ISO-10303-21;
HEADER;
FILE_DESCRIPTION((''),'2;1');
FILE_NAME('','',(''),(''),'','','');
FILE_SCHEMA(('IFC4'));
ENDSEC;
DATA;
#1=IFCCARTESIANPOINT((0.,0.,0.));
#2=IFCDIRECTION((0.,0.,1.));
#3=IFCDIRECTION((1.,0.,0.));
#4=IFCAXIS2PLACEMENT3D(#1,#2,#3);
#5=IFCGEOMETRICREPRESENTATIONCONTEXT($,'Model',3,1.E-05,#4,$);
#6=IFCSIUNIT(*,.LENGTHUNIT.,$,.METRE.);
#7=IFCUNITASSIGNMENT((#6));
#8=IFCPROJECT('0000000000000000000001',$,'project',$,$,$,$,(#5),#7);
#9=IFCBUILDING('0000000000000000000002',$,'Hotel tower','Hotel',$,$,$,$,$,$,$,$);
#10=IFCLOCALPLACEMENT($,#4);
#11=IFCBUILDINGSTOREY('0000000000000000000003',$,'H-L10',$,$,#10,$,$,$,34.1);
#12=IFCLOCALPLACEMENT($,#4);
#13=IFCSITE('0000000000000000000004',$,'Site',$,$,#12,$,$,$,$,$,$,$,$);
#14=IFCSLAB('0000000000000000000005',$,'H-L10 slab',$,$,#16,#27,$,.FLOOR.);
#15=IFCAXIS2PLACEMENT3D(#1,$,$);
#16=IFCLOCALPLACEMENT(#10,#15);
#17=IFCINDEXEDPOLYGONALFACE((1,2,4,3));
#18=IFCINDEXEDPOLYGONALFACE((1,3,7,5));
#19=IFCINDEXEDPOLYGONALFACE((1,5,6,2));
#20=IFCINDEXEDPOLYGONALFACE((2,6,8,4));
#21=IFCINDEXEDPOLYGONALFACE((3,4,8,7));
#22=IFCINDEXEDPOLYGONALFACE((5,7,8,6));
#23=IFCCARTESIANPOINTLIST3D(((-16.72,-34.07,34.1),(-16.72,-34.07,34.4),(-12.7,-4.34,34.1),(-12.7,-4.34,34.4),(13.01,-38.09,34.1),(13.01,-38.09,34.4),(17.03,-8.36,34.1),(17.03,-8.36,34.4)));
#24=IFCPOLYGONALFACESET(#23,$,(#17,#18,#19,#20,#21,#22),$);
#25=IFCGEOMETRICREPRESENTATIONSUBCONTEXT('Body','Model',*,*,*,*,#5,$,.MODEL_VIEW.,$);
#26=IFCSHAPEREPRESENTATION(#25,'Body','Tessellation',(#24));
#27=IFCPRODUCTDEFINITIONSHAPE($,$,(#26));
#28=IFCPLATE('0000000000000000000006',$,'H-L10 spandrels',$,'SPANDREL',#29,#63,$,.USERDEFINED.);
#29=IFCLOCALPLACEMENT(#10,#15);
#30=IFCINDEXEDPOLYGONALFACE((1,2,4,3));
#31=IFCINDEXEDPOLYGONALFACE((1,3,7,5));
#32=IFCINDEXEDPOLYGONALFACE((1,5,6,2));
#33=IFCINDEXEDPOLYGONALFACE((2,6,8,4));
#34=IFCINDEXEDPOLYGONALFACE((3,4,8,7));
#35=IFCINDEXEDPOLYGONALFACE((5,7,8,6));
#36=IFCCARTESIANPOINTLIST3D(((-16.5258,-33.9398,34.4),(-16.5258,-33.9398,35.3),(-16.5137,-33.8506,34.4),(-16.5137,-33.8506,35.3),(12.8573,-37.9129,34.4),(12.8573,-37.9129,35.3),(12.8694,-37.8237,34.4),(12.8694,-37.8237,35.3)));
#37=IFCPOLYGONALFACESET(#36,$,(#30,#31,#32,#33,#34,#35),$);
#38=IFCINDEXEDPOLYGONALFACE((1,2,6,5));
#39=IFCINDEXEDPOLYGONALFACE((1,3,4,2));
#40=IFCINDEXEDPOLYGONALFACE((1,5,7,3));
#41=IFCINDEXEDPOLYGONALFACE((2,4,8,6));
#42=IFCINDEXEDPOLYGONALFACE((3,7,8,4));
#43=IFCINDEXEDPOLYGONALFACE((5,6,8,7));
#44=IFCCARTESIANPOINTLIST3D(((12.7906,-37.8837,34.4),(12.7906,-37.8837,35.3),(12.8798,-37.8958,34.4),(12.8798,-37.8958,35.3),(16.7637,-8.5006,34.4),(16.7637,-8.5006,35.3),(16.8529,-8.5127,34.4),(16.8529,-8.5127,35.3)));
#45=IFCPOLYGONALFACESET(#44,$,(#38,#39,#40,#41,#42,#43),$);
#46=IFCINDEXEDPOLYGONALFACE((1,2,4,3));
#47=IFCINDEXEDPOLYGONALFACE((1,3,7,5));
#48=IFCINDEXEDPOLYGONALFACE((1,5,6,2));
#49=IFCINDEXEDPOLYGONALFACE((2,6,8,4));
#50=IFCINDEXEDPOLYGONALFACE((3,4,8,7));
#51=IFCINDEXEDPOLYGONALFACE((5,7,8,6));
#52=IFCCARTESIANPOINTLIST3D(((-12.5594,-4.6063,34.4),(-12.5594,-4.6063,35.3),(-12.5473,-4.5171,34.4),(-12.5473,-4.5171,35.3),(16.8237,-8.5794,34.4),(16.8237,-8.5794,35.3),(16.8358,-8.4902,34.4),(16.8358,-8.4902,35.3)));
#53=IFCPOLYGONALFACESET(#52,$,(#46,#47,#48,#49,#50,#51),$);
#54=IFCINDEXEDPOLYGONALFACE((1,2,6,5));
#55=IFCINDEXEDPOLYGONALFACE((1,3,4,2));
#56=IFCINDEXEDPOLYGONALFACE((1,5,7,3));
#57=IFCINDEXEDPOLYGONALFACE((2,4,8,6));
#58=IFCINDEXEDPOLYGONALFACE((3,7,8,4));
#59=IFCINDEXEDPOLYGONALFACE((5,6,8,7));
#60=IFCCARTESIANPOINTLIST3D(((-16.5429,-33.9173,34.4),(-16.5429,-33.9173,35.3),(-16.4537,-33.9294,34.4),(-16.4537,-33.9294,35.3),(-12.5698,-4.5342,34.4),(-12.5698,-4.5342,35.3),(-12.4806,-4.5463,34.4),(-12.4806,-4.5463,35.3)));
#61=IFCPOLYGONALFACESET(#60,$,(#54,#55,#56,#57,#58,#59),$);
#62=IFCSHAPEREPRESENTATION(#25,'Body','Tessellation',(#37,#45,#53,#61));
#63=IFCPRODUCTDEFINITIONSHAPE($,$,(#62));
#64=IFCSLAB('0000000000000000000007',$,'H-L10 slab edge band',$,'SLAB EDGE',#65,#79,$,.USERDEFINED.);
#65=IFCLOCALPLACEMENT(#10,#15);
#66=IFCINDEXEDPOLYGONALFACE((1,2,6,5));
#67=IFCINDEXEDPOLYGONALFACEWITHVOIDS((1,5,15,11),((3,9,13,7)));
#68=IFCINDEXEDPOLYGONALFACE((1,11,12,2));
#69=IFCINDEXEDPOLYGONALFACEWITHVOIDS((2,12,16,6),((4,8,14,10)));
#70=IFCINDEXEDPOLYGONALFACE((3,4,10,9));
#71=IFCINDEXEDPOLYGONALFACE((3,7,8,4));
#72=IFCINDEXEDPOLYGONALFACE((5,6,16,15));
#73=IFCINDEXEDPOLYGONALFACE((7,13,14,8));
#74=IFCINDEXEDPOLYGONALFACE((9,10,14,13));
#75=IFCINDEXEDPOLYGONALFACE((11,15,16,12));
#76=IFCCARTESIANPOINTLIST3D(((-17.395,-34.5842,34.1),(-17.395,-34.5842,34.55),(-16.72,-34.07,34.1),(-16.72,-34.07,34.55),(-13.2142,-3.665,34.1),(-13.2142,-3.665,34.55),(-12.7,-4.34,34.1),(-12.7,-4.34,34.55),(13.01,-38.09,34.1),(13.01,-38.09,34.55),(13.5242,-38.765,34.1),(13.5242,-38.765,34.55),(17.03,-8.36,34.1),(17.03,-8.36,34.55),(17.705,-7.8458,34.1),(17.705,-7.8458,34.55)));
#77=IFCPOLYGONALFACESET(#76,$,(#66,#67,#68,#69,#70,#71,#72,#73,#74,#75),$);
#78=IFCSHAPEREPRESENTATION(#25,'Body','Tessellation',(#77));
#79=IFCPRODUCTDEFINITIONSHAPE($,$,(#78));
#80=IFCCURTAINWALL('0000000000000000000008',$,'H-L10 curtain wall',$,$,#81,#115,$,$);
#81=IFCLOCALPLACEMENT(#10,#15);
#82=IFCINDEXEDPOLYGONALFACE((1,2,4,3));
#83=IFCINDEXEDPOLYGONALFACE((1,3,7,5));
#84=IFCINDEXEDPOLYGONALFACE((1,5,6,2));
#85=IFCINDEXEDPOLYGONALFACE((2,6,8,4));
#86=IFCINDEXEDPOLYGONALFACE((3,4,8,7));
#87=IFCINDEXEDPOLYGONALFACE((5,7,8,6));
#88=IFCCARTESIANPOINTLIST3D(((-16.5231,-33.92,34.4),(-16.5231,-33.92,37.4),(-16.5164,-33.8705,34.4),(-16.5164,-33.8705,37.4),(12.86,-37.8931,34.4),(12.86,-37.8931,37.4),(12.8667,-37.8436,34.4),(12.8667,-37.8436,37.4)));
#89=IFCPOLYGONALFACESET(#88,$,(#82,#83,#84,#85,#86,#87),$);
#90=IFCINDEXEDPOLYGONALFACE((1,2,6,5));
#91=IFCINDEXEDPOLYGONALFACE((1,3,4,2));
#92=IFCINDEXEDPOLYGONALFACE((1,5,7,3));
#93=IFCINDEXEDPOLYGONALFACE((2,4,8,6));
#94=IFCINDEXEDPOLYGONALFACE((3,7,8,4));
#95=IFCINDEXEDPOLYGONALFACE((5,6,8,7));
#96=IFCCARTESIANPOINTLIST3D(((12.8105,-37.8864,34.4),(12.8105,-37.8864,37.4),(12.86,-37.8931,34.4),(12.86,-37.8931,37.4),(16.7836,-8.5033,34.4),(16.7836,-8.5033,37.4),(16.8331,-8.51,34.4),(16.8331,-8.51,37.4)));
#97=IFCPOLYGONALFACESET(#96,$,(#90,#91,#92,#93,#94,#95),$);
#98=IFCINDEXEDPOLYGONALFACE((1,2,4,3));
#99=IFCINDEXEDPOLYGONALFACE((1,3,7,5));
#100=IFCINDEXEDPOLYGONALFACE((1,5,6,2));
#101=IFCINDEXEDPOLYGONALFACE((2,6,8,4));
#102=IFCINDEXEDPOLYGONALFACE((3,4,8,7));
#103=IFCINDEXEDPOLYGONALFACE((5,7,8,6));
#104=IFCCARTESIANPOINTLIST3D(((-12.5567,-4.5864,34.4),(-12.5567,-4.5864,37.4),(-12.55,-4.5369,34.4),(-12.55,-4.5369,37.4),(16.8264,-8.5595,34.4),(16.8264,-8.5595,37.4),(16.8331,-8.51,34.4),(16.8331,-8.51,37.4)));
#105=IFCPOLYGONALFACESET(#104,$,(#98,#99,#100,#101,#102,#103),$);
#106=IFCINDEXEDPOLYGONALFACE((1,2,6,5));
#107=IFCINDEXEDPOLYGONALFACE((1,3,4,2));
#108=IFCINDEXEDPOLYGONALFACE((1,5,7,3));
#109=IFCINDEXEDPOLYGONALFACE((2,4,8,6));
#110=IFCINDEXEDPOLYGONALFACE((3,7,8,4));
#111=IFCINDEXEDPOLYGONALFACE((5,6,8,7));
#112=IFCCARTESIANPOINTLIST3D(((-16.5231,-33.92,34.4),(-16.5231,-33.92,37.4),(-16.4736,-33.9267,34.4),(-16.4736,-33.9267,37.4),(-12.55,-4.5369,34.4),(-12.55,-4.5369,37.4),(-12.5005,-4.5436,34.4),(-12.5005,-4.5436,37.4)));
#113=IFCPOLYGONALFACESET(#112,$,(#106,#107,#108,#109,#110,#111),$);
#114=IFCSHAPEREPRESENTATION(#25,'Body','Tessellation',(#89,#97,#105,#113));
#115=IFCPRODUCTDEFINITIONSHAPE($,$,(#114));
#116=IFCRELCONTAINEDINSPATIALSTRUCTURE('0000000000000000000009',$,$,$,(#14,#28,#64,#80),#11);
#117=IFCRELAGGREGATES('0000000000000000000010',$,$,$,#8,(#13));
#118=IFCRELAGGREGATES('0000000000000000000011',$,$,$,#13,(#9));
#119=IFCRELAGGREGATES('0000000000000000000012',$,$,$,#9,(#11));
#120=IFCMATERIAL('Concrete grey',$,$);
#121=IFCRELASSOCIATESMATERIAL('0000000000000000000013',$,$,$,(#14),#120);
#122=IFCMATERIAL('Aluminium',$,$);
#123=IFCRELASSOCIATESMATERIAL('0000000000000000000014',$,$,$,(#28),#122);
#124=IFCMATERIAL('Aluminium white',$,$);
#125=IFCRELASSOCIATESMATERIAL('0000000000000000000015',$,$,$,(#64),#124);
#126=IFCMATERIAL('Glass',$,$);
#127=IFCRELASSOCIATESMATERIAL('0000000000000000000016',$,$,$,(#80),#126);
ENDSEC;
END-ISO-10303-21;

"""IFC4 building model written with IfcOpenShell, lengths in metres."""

from ifc_helpers import new_model, si_unit, frame, origin_with_axes, place, context, subcontext, project, spatial, polyline, outline, extrude, material, element, save


model = new_model("IFC4")

# Units and contexts
model_context = context("Model", 3, precision=1e-05, world=origin_with_axes())
body_context = subcontext(model_context, "Body", "Model", "MODEL_VIEW")
ifc_project = project(units=[si_unit("LENGTHUNIT", "METRE")], contexts=[model_context])

# Site, building, storey
site_placement = place(None, origin_with_axes())
site = spatial("IfcSite", under=ifc_project, at=site_placement, Name="Site")
building = spatial("IfcBuilding", under=site, Name="Hotel tower", Description="Hotel")
storey_placement = place(None, origin_with_axes())
storey = spatial("IfcBuildingStorey", under=building, at=storey_placement, Name="H-L10", Elevation=34.1)

# Shared definitions
ifc_material_1 = material(Name="Aluminium")

# Slab
ifc_material_2 = material(Name="Concrete grey")
slab_1_placement = place(storey_placement, origin_with_axes())
element("IfcSlab", 1, at=slab_1_placement, inside=storey, material=ifc_material_2, Name="H-L10 slab", PredefinedType="FLOOR", context=body_context, shape_type="SweptSolid", body=[
    extrude(outline(polyline([(-16.72, -34.07), (13.01, -38.09), (17.03, -8.36), (-12.7, -4.34), (-16.72, -34.07)])), frame((0.0, 0.0, 34.1), z_axis=(0.0, 0.0, 1.0), x_axis=(1.0, 0.0, 0.0)), (0.0, 0.0, 1.0), 0.3),
])

# Plate
plate_placement = place(storey_placement, origin_with_axes())
element("IfcPlate", 2, at=plate_placement, inside=storey, material=ifc_material_1, Name="H-L10 spandrels", ObjectType="SPANDREL", PredefinedType="USERDEFINED", context=body_context, shape_type="SweptSolid", body=[
    extrude(outline(polyline([(-16.5258, -33.9398), (12.8573, -37.9129), (12.8694, -37.8237), (-16.5137, -33.8506), (-16.5258, -33.9398)])), frame((0.0, 0.0, 34.4), z_axis=(0.0, 0.0, 1.0), x_axis=(1.0, 0.0, 0.0)), (0.0, 0.0, 1.0), 0.9),
    extrude(outline(polyline([(12.8798, -37.8958), (16.8529, -8.5127), (16.7637, -8.5006), (12.7906, -37.8837), (12.8798, -37.8958)])), frame((0.0, 0.0, 34.4), z_axis=(0.0, 0.0, 1.0), x_axis=(1.0, 0.0, 0.0)), (0.0, 0.0, 1.0), 0.9),
    extrude(outline(polyline([(16.8358, -8.4902), (-12.5473, -4.5171), (-12.5594, -4.6063), (16.8237, -8.5794), (16.8358, -8.4902)])), frame((0.0, 0.0, 34.4), z_axis=(0.0, 0.0, 1.0), x_axis=(1.0, 0.0, 0.0)), (0.0, 0.0, 1.0), 0.9),
    extrude(outline(polyline([(-12.5698, -4.5342), (-16.5429, -33.9173), (-16.4537, -33.9294), (-12.4806, -4.5463), (-12.5698, -4.5342)])), frame((0.0, 0.0, 34.4), z_axis=(0.0, 0.0, 1.0), x_axis=(1.0, 0.0, 0.0)), (0.0, 0.0, 1.0), 0.9),
])

# Slab
ifc_material_3 = material(Name="Aluminium white")
slab_2_placement = place(storey_placement, origin_with_axes())
element("IfcSlab", 3, at=slab_2_placement, inside=storey, material=ifc_material_3, Name="H-L10 slab edge band", ObjectType="SLAB EDGE", PredefinedType="USERDEFINED", context=body_context, shape_type="SweptSolid", body=[
    extrude(outline(polyline([(-17.395, -34.5842), (13.5242, -38.765), (17.705, -7.8458), (-13.2142, -3.665), (-17.395, -34.5842)]), holes=[polyline([(-16.72, -34.07), (13.01, -38.09), (17.03, -8.36), (-12.7, -4.34), (-16.72, -34.07)])]), frame((0.0, 0.0, 34.1), z_axis=(0.0, 0.0, 1.0), x_axis=(1.0, 0.0, 0.0)), (0.0, 0.0, 1.0), 0.45),
])

# Curtain wall
ifc_material_4 = material(Name="Glass")
curtain_wall_placement = place(storey_placement, origin_with_axes())
element("IfcCurtainWall", 4, at=curtain_wall_placement, inside=storey, material=ifc_material_4, Name="H-L10 curtain wall", context=body_context, shape_type="SweptSolid", body=[
    extrude(outline(polyline([(-16.5231, -33.92), (12.86, -37.8931), (12.8667, -37.8436), (-16.5164, -33.8705), (-16.5231, -33.92)])), frame((0.0, 0.0, 34.4), z_axis=(0.0, 0.0, 1.0), x_axis=(1.0, 0.0, 0.0)), (0.0, 0.0, 1.0), 3.0),
    extrude(outline(polyline([(12.86, -37.8931), (16.8331, -8.51), (16.7836, -8.5033), (12.8105, -37.8864), (12.86, -37.8931)])), frame((0.0, 0.0, 34.4), z_axis=(0.0, 0.0, 1.0), x_axis=(1.0, 0.0, 0.0)), (0.0, 0.0, 1.0), 3.0),
    extrude(outline(polyline([(16.8331, -8.51), (-12.55, -4.5369), (-12.5567, -4.5864), (16.8264, -8.5595), (16.8331, -8.51)])), frame((0.0, 0.0, 34.4), z_axis=(0.0, 0.0, 1.0), x_axis=(1.0, 0.0, 0.0)), (0.0, 0.0, 1.0), 3.0),
    extrude(outline(polyline([(-12.55, -4.5369), (-16.5231, -33.92), (-16.4736, -33.9267), (-12.5005, -4.5436), (-12.55, -4.5369)])), frame((0.0, 0.0, 34.4), z_axis=(0.0, 0.0, 1.0), x_axis=(1.0, 0.0, 0.0)), (0.0, 0.0, 1.0), 3.0),
])

save(model, "model.ifc")
